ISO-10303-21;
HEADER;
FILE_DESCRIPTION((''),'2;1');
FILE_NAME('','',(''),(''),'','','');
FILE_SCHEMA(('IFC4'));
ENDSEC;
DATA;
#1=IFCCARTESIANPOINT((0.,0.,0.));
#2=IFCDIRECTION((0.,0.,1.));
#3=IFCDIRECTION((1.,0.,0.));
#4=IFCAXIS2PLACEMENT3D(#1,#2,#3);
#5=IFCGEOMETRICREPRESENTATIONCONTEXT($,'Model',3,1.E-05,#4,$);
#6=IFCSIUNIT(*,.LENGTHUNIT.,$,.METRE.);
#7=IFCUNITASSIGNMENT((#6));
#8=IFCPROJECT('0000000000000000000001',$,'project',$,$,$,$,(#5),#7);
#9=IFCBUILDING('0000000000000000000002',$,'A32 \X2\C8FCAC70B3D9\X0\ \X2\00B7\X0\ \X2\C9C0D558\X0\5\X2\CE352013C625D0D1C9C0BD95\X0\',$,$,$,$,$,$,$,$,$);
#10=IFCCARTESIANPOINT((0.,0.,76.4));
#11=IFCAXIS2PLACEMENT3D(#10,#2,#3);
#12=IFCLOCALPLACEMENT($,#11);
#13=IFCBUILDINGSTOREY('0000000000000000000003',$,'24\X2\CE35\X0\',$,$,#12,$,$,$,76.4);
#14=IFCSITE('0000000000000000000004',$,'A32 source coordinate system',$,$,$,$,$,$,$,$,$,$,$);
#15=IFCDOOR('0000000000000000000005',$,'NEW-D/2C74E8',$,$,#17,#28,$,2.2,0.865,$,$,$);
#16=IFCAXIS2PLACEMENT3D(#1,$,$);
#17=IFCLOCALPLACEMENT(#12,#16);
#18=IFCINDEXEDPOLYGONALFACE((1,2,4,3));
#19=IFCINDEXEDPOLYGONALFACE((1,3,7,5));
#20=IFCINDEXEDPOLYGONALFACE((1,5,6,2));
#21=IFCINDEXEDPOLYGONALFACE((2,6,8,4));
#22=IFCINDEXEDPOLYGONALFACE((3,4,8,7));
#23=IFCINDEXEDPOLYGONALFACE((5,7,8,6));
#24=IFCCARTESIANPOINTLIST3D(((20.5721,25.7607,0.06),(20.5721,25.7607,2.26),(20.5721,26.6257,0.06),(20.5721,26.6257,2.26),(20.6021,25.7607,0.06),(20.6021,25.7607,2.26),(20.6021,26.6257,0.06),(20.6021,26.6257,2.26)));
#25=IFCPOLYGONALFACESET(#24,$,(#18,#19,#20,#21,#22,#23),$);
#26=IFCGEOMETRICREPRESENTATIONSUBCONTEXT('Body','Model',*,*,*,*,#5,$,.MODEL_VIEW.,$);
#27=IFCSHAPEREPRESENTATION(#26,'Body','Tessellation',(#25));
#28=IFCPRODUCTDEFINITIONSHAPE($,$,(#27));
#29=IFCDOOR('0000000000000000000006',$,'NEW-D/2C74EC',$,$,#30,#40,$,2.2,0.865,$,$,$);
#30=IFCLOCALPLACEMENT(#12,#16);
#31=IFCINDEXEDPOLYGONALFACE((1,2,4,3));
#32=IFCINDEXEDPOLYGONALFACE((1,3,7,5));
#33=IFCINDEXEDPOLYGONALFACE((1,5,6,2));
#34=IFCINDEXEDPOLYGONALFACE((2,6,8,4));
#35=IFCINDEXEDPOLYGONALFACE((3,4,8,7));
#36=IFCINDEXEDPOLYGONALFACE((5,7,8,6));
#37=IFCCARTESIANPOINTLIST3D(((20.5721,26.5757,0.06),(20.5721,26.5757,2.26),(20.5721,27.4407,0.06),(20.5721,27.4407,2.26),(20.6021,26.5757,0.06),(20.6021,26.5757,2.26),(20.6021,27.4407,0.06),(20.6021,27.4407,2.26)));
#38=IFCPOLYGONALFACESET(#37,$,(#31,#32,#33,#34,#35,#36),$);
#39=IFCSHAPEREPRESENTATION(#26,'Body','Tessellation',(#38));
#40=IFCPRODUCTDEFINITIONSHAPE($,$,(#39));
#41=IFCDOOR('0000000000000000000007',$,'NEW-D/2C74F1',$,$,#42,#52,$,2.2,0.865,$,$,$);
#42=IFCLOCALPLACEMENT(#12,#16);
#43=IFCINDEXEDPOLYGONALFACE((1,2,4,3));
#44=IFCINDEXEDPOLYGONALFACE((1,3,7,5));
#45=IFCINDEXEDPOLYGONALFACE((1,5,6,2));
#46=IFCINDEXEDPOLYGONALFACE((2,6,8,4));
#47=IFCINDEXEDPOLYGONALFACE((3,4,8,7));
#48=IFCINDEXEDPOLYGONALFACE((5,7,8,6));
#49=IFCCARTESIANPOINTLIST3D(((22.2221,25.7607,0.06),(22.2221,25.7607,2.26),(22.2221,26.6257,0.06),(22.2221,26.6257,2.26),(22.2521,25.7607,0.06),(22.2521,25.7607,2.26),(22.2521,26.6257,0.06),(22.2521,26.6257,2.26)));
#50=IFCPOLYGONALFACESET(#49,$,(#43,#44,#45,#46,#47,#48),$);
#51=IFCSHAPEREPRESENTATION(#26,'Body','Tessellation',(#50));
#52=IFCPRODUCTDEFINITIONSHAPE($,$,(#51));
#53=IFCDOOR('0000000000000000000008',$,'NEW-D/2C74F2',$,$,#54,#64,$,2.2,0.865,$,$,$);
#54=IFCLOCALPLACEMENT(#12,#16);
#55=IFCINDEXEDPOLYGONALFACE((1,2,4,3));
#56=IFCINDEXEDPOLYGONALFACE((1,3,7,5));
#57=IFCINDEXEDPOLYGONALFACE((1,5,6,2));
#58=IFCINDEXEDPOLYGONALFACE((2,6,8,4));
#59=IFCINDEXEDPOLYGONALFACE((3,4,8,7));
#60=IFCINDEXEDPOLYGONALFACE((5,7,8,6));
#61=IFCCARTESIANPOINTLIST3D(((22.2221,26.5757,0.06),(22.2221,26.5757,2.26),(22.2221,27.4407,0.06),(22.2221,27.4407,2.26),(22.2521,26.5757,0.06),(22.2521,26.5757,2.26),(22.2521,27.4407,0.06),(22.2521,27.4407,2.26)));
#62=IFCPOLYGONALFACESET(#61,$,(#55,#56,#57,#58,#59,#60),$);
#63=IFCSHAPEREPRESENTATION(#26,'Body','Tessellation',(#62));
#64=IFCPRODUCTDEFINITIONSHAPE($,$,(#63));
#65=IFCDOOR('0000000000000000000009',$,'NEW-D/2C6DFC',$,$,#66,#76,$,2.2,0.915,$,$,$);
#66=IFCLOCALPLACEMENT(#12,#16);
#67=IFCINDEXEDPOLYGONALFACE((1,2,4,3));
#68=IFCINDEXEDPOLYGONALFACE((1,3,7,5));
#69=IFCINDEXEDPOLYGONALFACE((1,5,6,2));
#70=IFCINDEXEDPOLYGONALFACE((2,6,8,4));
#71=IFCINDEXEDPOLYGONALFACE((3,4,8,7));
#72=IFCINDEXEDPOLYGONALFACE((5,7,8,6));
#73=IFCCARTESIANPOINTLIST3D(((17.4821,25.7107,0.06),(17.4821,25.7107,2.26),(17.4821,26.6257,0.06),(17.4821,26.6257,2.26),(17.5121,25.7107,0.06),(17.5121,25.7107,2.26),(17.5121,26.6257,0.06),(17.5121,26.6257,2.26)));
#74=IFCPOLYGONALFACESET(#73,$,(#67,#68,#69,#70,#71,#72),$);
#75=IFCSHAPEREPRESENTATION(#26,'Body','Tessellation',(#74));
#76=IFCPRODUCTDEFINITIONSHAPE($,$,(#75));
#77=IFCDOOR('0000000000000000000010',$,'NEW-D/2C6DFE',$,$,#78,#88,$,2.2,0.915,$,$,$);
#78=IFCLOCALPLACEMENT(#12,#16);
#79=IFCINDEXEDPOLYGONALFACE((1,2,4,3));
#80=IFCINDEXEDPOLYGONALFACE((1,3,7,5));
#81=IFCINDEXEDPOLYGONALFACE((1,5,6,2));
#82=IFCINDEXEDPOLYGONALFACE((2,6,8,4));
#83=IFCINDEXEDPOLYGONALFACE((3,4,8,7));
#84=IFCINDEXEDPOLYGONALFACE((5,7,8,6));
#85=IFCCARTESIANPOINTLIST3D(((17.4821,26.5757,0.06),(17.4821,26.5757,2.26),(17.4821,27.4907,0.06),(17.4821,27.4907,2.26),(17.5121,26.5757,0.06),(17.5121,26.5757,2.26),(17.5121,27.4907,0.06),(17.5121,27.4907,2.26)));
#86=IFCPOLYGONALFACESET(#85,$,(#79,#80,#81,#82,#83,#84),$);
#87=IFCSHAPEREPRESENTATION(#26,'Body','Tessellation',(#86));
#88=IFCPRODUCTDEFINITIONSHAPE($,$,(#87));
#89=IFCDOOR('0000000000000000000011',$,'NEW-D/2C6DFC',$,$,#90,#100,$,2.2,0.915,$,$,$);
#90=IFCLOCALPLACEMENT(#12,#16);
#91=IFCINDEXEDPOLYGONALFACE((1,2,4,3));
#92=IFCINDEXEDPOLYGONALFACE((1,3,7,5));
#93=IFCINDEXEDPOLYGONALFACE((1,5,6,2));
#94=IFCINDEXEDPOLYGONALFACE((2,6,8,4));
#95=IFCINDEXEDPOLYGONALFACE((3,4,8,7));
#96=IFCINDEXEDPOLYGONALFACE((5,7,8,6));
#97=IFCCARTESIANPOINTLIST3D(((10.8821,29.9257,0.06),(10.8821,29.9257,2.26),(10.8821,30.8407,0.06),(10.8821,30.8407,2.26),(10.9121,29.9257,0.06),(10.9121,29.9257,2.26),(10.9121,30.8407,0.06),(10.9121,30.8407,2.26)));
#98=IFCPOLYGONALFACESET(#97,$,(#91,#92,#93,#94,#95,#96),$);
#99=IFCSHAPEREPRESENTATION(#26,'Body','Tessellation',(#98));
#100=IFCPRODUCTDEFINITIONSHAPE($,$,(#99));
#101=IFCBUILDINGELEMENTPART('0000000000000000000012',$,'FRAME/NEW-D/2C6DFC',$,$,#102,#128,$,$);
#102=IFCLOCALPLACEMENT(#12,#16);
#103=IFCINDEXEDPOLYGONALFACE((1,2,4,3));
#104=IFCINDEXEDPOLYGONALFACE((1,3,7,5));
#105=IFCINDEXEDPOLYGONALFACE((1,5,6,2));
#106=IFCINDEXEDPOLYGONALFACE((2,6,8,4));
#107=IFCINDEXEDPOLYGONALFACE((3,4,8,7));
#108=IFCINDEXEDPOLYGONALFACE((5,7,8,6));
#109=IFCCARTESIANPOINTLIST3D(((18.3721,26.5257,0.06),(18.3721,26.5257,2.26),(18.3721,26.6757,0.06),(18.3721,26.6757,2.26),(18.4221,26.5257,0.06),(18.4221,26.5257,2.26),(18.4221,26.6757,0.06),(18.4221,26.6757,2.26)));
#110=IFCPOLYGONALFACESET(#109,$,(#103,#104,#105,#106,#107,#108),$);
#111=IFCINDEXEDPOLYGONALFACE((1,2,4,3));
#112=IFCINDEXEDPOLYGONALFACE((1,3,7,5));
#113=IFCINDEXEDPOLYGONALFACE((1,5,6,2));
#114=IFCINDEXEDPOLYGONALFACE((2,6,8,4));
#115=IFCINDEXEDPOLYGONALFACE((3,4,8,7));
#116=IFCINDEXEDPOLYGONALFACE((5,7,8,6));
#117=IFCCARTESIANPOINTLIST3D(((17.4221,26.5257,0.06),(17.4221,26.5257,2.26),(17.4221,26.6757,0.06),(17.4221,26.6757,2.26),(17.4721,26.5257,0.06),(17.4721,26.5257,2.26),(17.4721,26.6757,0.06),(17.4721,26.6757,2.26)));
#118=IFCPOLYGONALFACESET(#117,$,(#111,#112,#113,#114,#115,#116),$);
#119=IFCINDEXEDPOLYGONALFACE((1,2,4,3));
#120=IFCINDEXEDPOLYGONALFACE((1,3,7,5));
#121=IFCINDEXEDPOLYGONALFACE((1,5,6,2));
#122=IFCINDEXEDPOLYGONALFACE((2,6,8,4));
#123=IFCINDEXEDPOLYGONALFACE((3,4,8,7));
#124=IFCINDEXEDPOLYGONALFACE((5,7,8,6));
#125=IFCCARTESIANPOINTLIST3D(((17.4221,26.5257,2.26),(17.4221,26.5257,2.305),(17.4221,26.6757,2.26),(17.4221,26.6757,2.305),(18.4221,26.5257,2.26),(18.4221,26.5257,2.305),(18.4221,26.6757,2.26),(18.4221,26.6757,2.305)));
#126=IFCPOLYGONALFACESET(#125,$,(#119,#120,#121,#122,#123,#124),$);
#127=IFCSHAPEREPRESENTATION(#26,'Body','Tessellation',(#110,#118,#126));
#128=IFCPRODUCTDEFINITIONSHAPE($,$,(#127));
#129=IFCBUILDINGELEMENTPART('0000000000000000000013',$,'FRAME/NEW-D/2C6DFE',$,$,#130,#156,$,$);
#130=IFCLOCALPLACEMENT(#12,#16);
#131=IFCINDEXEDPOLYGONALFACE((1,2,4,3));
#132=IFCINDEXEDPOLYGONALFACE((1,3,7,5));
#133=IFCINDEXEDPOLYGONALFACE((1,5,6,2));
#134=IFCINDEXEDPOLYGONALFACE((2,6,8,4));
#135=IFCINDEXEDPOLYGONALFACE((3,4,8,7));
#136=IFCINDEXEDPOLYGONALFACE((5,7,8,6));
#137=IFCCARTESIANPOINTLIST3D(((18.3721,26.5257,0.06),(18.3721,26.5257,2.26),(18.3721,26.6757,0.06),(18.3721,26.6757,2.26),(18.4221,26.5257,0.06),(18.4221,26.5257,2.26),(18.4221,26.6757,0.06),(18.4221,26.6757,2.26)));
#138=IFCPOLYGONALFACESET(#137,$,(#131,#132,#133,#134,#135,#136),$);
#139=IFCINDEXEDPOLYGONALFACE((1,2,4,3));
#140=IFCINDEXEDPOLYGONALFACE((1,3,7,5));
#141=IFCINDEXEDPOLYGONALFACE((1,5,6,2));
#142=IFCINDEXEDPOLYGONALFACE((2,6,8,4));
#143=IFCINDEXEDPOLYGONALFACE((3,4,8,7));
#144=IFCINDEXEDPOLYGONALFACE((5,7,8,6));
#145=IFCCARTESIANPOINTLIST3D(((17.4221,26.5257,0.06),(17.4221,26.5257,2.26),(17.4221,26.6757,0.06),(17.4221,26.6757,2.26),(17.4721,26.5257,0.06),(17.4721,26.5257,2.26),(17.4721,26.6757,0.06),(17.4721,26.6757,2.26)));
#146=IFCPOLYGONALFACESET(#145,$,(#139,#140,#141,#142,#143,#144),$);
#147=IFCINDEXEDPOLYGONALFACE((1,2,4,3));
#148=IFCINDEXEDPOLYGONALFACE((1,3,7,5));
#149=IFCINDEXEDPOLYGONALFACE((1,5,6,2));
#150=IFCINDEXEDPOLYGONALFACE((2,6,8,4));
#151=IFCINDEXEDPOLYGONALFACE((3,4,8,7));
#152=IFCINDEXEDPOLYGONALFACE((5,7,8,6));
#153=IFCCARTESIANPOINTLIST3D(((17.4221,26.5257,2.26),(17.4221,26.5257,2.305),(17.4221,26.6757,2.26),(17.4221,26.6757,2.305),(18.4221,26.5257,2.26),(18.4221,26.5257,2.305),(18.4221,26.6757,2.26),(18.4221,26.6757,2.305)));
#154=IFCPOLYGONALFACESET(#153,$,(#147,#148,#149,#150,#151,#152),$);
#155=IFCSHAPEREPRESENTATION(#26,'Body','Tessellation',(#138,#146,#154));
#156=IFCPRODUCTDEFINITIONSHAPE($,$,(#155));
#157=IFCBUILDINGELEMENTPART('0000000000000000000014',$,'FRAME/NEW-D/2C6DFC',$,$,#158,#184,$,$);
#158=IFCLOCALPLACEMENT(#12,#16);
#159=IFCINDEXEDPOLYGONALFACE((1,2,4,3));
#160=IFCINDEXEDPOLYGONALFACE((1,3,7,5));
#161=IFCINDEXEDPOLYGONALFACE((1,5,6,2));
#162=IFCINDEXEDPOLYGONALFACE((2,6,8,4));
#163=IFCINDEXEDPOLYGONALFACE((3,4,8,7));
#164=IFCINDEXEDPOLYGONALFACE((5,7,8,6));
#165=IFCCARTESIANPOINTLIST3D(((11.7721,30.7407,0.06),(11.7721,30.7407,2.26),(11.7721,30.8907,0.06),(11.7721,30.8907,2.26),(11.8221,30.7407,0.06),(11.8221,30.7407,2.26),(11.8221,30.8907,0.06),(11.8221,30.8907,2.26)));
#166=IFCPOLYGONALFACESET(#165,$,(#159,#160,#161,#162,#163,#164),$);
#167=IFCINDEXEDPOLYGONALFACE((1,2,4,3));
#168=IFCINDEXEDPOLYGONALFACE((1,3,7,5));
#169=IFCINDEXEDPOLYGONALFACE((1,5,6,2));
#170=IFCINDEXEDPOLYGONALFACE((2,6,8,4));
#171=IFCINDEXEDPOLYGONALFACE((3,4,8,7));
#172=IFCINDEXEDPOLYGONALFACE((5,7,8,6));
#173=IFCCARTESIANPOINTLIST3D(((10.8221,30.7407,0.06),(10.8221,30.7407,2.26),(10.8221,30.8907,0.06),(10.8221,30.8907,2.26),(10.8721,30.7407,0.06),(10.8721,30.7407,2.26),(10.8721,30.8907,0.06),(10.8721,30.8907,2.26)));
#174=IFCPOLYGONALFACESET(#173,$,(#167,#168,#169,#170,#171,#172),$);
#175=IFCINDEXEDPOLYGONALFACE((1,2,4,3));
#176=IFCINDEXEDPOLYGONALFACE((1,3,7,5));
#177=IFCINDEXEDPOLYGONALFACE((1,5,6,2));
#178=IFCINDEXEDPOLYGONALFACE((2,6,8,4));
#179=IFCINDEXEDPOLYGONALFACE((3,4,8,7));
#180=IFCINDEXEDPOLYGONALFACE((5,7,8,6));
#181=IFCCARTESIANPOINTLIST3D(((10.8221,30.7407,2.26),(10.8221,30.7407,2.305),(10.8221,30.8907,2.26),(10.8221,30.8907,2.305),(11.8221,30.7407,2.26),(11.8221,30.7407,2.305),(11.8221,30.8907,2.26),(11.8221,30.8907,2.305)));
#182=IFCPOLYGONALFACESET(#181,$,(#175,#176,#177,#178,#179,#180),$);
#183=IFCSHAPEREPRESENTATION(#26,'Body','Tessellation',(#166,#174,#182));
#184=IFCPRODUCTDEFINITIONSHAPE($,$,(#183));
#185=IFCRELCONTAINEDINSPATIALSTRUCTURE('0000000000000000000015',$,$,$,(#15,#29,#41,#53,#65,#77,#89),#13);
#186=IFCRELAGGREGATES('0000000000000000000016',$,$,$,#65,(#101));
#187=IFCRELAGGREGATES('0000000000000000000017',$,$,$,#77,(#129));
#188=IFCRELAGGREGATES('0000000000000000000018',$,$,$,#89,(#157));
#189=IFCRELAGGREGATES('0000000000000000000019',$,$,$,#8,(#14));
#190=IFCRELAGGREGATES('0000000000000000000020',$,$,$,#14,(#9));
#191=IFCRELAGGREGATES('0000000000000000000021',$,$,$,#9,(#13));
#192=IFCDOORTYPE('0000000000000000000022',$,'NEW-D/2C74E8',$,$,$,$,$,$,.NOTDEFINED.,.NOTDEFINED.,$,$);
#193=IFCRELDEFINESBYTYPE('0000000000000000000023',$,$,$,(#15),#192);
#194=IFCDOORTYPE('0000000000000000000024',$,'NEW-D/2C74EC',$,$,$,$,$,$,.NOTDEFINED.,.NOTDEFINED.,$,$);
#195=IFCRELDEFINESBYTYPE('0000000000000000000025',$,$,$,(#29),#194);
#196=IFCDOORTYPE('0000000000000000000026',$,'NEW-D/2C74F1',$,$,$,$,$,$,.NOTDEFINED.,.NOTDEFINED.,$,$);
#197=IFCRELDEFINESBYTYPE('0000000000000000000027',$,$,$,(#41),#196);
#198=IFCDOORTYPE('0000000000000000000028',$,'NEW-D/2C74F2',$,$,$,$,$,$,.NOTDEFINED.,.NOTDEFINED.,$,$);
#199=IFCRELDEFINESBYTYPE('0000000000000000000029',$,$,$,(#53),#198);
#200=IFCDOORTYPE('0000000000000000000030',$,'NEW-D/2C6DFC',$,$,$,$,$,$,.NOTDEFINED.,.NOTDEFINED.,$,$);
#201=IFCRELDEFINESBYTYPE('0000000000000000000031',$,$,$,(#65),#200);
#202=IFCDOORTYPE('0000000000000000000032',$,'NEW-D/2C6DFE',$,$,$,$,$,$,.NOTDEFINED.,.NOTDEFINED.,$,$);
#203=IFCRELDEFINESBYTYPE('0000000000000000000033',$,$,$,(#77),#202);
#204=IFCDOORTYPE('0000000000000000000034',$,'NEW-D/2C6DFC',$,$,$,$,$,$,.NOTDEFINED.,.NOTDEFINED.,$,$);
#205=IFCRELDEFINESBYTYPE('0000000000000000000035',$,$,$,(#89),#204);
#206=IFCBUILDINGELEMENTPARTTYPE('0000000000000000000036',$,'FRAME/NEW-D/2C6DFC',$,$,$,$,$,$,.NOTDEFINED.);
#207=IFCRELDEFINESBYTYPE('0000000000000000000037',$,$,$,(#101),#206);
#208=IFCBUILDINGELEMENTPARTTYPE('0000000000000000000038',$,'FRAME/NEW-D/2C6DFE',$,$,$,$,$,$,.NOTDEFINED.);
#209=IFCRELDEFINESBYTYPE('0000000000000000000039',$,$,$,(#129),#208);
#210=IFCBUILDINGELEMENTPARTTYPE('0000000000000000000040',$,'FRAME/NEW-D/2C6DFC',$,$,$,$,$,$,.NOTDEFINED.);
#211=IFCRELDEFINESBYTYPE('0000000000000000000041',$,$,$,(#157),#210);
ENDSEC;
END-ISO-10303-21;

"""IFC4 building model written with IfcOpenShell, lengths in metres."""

from ifc_helpers import new_model, si_unit, frame, origin, origin_with_axes, place, context, subcontext, project, spatial, polyline, outline, extrude, source, transform, mapped, type_object, type_shapes, element, aggregate, save


model = new_model("IFC4")

# Units and contexts
model_context = context("Model", 3, precision=1e-05, world=origin_with_axes())
body_context = subcontext(model_context, "Body", "Model", "MODEL_VIEW")
ifc_project = project(units=[si_unit("LENGTHUNIT", "METRE")], contexts=[model_context])

# Site, building, storey
site = spatial("IfcSite", under=ifc_project, Name="A32 source coordinate system")
building = spatial("IfcBuilding", under=site, Name="A32 주거동 · 지하5층–옥탑지붕")
storey_placement = place(None, frame((0.0, 0.0, 76.4), z_axis=(0.0, 0.0, 1.0), x_axis=(1.0, 0.0, 0.0)))
storey = spatial("IfcBuildingStorey", under=building, at=storey_placement, Name="24층", Elevation=76.4)

# Doors
door_type_1 = type_object("IfcDoorType", Name="NEW-D/2C74E8", OperationType="NOTDEFINED", PredefinedType="NOTDEFINED")
shared_shape_1 = source(origin(), body_context, "Body", "SweptSolid", [
    extrude(outline(polyline([(20.6021, 26.6257), (20.6021, 25.7607), (20.5721, 25.7607), (20.5721, 26.6257), (20.6021, 26.6257)])), frame((0.0, 0.0, 0.06)), (0.0, 0.0, 1.0), 2.2),
])
type_shapes(door_type_1, [shared_shape_1])
door_1_placement = place(storey_placement, origin_with_axes())
element("IfcDoor", 1, at=door_1_placement, inside=storey, type_object=door_type_1, Name="NEW-D/2C74E8", OverallHeight=2.2, OverallWidth=0.865, context=body_context, shape_type="MappedRepresentation", body=[
    mapped(shared_shape_1, transform((0.0, 0.0, 0.0), scale=1.0)),
])
door_type_2 = type_object("IfcDoorType", Name="NEW-D/2C74EC", OperationType="NOTDEFINED", PredefinedType="NOTDEFINED")
shared_shape_2 = source(origin(), body_context, "Body", "SweptSolid", [
    extrude(outline(polyline([(20.5721, 27.4407), (20.6021, 27.4407), (20.6021, 26.5757), (20.5721, 26.5757), (20.5721, 27.4407)])), frame((0.0, 0.0, 0.06)), (0.0, 0.0, 1.0), 2.2),
])
type_shapes(door_type_2, [shared_shape_2])
door_2_placement = place(storey_placement, origin_with_axes())
element("IfcDoor", 2, at=door_2_placement, inside=storey, type_object=door_type_2, Name="NEW-D/2C74EC", OverallHeight=2.2, OverallWidth=0.865, context=body_context, shape_type="MappedRepresentation", body=[
    mapped(shared_shape_2, transform((0.0, 0.0, 0.0), scale=1.0)),
])
door_type_3 = type_object("IfcDoorType", Name="NEW-D/2C74F1", OperationType="NOTDEFINED", PredefinedType="NOTDEFINED")
shared_shape_3 = source(origin(), body_context, "Body", "SweptSolid", [
    extrude(outline(polyline([(22.2521, 25.7607), (22.2221, 25.7607), (22.2221, 26.6257), (22.2521, 26.6257), (22.2521, 25.7607)])), frame((0.0, 0.0, 0.06)), (0.0, 0.0, 1.0), 2.2),
])
type_shapes(door_type_3, [shared_shape_3])
door_3_placement = place(storey_placement, origin_with_axes())
element("IfcDoor", 3, at=door_3_placement, inside=storey, type_object=door_type_3, Name="NEW-D/2C74F1", OverallHeight=2.2, OverallWidth=0.865, context=body_context, shape_type="MappedRepresentation", body=[
    mapped(shared_shape_3, transform((0.0, 0.0, 0.0), scale=1.0)),
])
door_type_4 = type_object("IfcDoorType", Name="NEW-D/2C74F2", OperationType="NOTDEFINED", PredefinedType="NOTDEFINED")
shared_shape_4 = source(origin(), body_context, "Body", "SweptSolid", [
    extrude(outline(polyline([(22.2221, 26.5757), (22.2221, 27.4407), (22.2521, 27.4407), (22.2521, 26.5757), (22.2221, 26.5757)])), frame((0.0, 0.0, 0.06)), (0.0, 0.0, 1.0), 2.2),
])
type_shapes(door_type_4, [shared_shape_4])
door_4_placement = place(storey_placement, origin_with_axes())
element("IfcDoor", 4, at=door_4_placement, inside=storey, type_object=door_type_4, Name="NEW-D/2C74F2", OverallHeight=2.2, OverallWidth=0.865, context=body_context, shape_type="MappedRepresentation", body=[
    mapped(shared_shape_4, transform((0.0, 0.0, 0.0), scale=1.0)),
])

# Doors
door_type_5 = type_object("IfcDoorType", Name="NEW-D/2C6DFC", OperationType="NOTDEFINED", PredefinedType="NOTDEFINED")
shared_shape_5 = source(origin(), body_context, "Body", "SweptSolid", [
    extrude(outline(polyline([(17.5121, 26.6257), (17.5121, 25.7107), (17.4821, 25.7107), (17.4821, 26.6257), (17.5121, 26.6257)])), frame((0.0, 0.0, 0.06)), (0.0, 0.0, 1.0), 2.2),
])
type_shapes(door_type_5, [shared_shape_5])
door_5_placement = place(storey_placement, origin_with_axes())
door_5 = element("IfcDoor", 5, at=door_5_placement, inside=storey, type_object=door_type_5, Name="NEW-D/2C6DFC", OverallHeight=2.2, OverallWidth=0.915, context=body_context, shape_type="MappedRepresentation", body=[
    mapped(shared_shape_5, transform((0.0, 0.0, 0.0), scale=1.0)),
])
door_type_6 = type_object("IfcDoorType", Name="NEW-D/2C6DFE", OperationType="NOTDEFINED", PredefinedType="NOTDEFINED")
shared_shape_6 = source(origin(), body_context, "Body", "SweptSolid", [
    extrude(outline(polyline([(17.4821, 27.4907), (17.5121, 27.4907), (17.5121, 26.5757), (17.4821, 26.5757), (17.4821, 27.4907)])), frame((0.0, 0.0, 0.06)), (0.0, 0.0, 1.0), 2.2),
])
type_shapes(door_type_6, [shared_shape_6])
door_6_placement = place(storey_placement, origin_with_axes())
door_6 = element("IfcDoor", 6, at=door_6_placement, inside=storey, type_object=door_type_6, Name="NEW-D/2C6DFE", OverallHeight=2.2, OverallWidth=0.915, context=body_context, shape_type="MappedRepresentation", body=[
    mapped(shared_shape_6, transform((0.0, 0.0, 0.0), scale=1.0)),
])
door_type_7 = type_object("IfcDoorType", Name="NEW-D/2C6DFC", OperationType="NOTDEFINED", PredefinedType="NOTDEFINED")
shared_shape_7 = source(origin(), body_context, "Body", "SweptSolid", [
    extrude(outline(polyline([(10.9121, 30.8407), (10.9121, 29.9257), (10.8821, 29.9257), (10.8821, 30.8407), (10.9121, 30.8407)])), frame((0.0, 0.0, 0.06)), (0.0, 0.0, 1.0), 2.2),
])
type_shapes(door_type_7, [shared_shape_7])
door_7_placement = place(storey_placement, origin_with_axes())
door_7 = element("IfcDoor", 7, at=door_7_placement, inside=storey, type_object=door_type_7, Name="NEW-D/2C6DFC", OverallHeight=2.2, OverallWidth=0.915, context=body_context, shape_type="MappedRepresentation", body=[
    mapped(shared_shape_7, transform((0.0, 0.0, 0.0), scale=1.0)),
])

# Building element parts
building_element_part_type_1 = type_object("IfcBuildingElementPartType", Name="FRAME/NEW-D/2C6DFC", PredefinedType="NOTDEFINED")
shared_shape_8 = source(origin(), body_context, "Body", "SweptSolid", [
    extrude(outline(polyline([(18.4221, 26.6757), (18.4221, 26.5257), (18.3721, 26.5257), (18.3721, 26.6757), (18.4221, 26.6757)])), frame((0.0, 0.0, 0.06)), (0.0, 0.0, 1.0), 2.2),
    extrude(outline(polyline([(17.4721, 26.6757), (17.4721, 26.5257), (17.4221, 26.5257), (17.4221, 26.6757), (17.4721, 26.6757)])), frame((0.0, 0.0, 0.06)), (0.0, 0.0, 1.0), 2.2),
    extrude(outline(polyline([(18.4221, 26.5257), (18.4221, 26.6757), (17.4221, 26.6757), (17.4221, 26.5257), (18.4221, 26.5257)])), frame((0.0, 0.0, 2.26)), (0.0, 0.0, 1.0), 0.045),
])
type_shapes(building_element_part_type_1, [shared_shape_8])
building_element_part_1_placement = place(door_5_placement, origin_with_axes())
building_element_part_1 = element("IfcBuildingElementPart", 8, at=building_element_part_1_placement, type_object=building_element_part_type_1, Name="FRAME/NEW-D/2C6DFC", context=body_context, shape_type="MappedRepresentation", body=[
    mapped(shared_shape_8, transform((0.0, 0.0, 0.0), scale=1.0)),
])
aggregate(door_5, [building_element_part_1])
building_element_part_type_2 = type_object("IfcBuildingElementPartType", Name="FRAME/NEW-D/2C6DFE", PredefinedType="NOTDEFINED")
shared_shape_9 = source(origin(), body_context, "Body", "SweptSolid", [
    extrude(outline(polyline([(18.4221, 26.6757), (18.4221, 26.5257), (18.3721, 26.5257), (18.3721, 26.6757), (18.4221, 26.6757)])), frame((0.0, 0.0, 0.06)), (0.0, 0.0, 1.0), 2.2),
    extrude(outline(polyline([(17.4721, 26.6757), (17.4721, 26.5257), (17.4221, 26.5257), (17.4221, 26.6757), (17.4721, 26.6757)])), frame((0.0, 0.0, 0.06)), (0.0, 0.0, 1.0), 2.2),
    extrude(outline(polyline([(18.4221, 26.5257), (18.4221, 26.6757), (17.4221, 26.6757), (17.4221, 26.5257), (18.4221, 26.5257)])), frame((0.0, 0.0, 2.26)), (0.0, 0.0, 1.0), 0.045),
])
type_shapes(building_element_part_type_2, [shared_shape_9])
building_element_part_2_placement = place(door_6_placement, origin_with_axes())
building_element_part_2 = element("IfcBuildingElementPart", 9, at=building_element_part_2_placement, type_object=building_element_part_type_2, Name="FRAME/NEW-D/2C6DFE", context=body_context, shape_type="MappedRepresentation", body=[
    mapped(shared_shape_9, transform((0.0, 0.0, 0.0), scale=1.0)),
])
aggregate(door_6, [building_element_part_2])
building_element_part_type_3 = type_object("IfcBuildingElementPartType", Name="FRAME/NEW-D/2C6DFC", PredefinedType="NOTDEFINED")
shared_shape_10 = source(origin(), body_context, "Body", "SweptSolid", [
    extrude(outline(polyline([(11.8221, 30.8907), (11.8221, 30.7407), (11.7721, 30.7407), (11.7721, 30.8907), (11.8221, 30.8907)])), frame((0.0, 0.0, 0.06)), (0.0, 0.0, 1.0), 2.2),
    extrude(outline(polyline([(10.8721, 30.8907), (10.8721, 30.7407), (10.8221, 30.7407), (10.8221, 30.8907), (10.8721, 30.8907)])), frame((0.0, 0.0, 0.06)), (0.0, 0.0, 1.0), 2.2),
    extrude(outline(polyline([(11.8221, 30.7407), (11.8221, 30.8907), (10.8221, 30.8907), (10.8221, 30.7407), (11.8221, 30.7407)])), frame((0.0, 0.0, 2.26)), (0.0, 0.0, 1.0), 0.045),
])
type_shapes(building_element_part_type_3, [shared_shape_10])
building_element_part_3_placement = place(door_7_placement, origin_with_axes())
building_element_part_3 = element("IfcBuildingElementPart", 10, at=building_element_part_3_placement, type_object=building_element_part_type_3, Name="FRAME/NEW-D/2C6DFC", context=body_context, shape_type="MappedRepresentation", body=[
    mapped(shared_shape_10, transform((0.0, 0.0, 0.0), scale=1.0)),
])
aggregate(door_7, [building_element_part_3])

save(model, "model.ifc")
